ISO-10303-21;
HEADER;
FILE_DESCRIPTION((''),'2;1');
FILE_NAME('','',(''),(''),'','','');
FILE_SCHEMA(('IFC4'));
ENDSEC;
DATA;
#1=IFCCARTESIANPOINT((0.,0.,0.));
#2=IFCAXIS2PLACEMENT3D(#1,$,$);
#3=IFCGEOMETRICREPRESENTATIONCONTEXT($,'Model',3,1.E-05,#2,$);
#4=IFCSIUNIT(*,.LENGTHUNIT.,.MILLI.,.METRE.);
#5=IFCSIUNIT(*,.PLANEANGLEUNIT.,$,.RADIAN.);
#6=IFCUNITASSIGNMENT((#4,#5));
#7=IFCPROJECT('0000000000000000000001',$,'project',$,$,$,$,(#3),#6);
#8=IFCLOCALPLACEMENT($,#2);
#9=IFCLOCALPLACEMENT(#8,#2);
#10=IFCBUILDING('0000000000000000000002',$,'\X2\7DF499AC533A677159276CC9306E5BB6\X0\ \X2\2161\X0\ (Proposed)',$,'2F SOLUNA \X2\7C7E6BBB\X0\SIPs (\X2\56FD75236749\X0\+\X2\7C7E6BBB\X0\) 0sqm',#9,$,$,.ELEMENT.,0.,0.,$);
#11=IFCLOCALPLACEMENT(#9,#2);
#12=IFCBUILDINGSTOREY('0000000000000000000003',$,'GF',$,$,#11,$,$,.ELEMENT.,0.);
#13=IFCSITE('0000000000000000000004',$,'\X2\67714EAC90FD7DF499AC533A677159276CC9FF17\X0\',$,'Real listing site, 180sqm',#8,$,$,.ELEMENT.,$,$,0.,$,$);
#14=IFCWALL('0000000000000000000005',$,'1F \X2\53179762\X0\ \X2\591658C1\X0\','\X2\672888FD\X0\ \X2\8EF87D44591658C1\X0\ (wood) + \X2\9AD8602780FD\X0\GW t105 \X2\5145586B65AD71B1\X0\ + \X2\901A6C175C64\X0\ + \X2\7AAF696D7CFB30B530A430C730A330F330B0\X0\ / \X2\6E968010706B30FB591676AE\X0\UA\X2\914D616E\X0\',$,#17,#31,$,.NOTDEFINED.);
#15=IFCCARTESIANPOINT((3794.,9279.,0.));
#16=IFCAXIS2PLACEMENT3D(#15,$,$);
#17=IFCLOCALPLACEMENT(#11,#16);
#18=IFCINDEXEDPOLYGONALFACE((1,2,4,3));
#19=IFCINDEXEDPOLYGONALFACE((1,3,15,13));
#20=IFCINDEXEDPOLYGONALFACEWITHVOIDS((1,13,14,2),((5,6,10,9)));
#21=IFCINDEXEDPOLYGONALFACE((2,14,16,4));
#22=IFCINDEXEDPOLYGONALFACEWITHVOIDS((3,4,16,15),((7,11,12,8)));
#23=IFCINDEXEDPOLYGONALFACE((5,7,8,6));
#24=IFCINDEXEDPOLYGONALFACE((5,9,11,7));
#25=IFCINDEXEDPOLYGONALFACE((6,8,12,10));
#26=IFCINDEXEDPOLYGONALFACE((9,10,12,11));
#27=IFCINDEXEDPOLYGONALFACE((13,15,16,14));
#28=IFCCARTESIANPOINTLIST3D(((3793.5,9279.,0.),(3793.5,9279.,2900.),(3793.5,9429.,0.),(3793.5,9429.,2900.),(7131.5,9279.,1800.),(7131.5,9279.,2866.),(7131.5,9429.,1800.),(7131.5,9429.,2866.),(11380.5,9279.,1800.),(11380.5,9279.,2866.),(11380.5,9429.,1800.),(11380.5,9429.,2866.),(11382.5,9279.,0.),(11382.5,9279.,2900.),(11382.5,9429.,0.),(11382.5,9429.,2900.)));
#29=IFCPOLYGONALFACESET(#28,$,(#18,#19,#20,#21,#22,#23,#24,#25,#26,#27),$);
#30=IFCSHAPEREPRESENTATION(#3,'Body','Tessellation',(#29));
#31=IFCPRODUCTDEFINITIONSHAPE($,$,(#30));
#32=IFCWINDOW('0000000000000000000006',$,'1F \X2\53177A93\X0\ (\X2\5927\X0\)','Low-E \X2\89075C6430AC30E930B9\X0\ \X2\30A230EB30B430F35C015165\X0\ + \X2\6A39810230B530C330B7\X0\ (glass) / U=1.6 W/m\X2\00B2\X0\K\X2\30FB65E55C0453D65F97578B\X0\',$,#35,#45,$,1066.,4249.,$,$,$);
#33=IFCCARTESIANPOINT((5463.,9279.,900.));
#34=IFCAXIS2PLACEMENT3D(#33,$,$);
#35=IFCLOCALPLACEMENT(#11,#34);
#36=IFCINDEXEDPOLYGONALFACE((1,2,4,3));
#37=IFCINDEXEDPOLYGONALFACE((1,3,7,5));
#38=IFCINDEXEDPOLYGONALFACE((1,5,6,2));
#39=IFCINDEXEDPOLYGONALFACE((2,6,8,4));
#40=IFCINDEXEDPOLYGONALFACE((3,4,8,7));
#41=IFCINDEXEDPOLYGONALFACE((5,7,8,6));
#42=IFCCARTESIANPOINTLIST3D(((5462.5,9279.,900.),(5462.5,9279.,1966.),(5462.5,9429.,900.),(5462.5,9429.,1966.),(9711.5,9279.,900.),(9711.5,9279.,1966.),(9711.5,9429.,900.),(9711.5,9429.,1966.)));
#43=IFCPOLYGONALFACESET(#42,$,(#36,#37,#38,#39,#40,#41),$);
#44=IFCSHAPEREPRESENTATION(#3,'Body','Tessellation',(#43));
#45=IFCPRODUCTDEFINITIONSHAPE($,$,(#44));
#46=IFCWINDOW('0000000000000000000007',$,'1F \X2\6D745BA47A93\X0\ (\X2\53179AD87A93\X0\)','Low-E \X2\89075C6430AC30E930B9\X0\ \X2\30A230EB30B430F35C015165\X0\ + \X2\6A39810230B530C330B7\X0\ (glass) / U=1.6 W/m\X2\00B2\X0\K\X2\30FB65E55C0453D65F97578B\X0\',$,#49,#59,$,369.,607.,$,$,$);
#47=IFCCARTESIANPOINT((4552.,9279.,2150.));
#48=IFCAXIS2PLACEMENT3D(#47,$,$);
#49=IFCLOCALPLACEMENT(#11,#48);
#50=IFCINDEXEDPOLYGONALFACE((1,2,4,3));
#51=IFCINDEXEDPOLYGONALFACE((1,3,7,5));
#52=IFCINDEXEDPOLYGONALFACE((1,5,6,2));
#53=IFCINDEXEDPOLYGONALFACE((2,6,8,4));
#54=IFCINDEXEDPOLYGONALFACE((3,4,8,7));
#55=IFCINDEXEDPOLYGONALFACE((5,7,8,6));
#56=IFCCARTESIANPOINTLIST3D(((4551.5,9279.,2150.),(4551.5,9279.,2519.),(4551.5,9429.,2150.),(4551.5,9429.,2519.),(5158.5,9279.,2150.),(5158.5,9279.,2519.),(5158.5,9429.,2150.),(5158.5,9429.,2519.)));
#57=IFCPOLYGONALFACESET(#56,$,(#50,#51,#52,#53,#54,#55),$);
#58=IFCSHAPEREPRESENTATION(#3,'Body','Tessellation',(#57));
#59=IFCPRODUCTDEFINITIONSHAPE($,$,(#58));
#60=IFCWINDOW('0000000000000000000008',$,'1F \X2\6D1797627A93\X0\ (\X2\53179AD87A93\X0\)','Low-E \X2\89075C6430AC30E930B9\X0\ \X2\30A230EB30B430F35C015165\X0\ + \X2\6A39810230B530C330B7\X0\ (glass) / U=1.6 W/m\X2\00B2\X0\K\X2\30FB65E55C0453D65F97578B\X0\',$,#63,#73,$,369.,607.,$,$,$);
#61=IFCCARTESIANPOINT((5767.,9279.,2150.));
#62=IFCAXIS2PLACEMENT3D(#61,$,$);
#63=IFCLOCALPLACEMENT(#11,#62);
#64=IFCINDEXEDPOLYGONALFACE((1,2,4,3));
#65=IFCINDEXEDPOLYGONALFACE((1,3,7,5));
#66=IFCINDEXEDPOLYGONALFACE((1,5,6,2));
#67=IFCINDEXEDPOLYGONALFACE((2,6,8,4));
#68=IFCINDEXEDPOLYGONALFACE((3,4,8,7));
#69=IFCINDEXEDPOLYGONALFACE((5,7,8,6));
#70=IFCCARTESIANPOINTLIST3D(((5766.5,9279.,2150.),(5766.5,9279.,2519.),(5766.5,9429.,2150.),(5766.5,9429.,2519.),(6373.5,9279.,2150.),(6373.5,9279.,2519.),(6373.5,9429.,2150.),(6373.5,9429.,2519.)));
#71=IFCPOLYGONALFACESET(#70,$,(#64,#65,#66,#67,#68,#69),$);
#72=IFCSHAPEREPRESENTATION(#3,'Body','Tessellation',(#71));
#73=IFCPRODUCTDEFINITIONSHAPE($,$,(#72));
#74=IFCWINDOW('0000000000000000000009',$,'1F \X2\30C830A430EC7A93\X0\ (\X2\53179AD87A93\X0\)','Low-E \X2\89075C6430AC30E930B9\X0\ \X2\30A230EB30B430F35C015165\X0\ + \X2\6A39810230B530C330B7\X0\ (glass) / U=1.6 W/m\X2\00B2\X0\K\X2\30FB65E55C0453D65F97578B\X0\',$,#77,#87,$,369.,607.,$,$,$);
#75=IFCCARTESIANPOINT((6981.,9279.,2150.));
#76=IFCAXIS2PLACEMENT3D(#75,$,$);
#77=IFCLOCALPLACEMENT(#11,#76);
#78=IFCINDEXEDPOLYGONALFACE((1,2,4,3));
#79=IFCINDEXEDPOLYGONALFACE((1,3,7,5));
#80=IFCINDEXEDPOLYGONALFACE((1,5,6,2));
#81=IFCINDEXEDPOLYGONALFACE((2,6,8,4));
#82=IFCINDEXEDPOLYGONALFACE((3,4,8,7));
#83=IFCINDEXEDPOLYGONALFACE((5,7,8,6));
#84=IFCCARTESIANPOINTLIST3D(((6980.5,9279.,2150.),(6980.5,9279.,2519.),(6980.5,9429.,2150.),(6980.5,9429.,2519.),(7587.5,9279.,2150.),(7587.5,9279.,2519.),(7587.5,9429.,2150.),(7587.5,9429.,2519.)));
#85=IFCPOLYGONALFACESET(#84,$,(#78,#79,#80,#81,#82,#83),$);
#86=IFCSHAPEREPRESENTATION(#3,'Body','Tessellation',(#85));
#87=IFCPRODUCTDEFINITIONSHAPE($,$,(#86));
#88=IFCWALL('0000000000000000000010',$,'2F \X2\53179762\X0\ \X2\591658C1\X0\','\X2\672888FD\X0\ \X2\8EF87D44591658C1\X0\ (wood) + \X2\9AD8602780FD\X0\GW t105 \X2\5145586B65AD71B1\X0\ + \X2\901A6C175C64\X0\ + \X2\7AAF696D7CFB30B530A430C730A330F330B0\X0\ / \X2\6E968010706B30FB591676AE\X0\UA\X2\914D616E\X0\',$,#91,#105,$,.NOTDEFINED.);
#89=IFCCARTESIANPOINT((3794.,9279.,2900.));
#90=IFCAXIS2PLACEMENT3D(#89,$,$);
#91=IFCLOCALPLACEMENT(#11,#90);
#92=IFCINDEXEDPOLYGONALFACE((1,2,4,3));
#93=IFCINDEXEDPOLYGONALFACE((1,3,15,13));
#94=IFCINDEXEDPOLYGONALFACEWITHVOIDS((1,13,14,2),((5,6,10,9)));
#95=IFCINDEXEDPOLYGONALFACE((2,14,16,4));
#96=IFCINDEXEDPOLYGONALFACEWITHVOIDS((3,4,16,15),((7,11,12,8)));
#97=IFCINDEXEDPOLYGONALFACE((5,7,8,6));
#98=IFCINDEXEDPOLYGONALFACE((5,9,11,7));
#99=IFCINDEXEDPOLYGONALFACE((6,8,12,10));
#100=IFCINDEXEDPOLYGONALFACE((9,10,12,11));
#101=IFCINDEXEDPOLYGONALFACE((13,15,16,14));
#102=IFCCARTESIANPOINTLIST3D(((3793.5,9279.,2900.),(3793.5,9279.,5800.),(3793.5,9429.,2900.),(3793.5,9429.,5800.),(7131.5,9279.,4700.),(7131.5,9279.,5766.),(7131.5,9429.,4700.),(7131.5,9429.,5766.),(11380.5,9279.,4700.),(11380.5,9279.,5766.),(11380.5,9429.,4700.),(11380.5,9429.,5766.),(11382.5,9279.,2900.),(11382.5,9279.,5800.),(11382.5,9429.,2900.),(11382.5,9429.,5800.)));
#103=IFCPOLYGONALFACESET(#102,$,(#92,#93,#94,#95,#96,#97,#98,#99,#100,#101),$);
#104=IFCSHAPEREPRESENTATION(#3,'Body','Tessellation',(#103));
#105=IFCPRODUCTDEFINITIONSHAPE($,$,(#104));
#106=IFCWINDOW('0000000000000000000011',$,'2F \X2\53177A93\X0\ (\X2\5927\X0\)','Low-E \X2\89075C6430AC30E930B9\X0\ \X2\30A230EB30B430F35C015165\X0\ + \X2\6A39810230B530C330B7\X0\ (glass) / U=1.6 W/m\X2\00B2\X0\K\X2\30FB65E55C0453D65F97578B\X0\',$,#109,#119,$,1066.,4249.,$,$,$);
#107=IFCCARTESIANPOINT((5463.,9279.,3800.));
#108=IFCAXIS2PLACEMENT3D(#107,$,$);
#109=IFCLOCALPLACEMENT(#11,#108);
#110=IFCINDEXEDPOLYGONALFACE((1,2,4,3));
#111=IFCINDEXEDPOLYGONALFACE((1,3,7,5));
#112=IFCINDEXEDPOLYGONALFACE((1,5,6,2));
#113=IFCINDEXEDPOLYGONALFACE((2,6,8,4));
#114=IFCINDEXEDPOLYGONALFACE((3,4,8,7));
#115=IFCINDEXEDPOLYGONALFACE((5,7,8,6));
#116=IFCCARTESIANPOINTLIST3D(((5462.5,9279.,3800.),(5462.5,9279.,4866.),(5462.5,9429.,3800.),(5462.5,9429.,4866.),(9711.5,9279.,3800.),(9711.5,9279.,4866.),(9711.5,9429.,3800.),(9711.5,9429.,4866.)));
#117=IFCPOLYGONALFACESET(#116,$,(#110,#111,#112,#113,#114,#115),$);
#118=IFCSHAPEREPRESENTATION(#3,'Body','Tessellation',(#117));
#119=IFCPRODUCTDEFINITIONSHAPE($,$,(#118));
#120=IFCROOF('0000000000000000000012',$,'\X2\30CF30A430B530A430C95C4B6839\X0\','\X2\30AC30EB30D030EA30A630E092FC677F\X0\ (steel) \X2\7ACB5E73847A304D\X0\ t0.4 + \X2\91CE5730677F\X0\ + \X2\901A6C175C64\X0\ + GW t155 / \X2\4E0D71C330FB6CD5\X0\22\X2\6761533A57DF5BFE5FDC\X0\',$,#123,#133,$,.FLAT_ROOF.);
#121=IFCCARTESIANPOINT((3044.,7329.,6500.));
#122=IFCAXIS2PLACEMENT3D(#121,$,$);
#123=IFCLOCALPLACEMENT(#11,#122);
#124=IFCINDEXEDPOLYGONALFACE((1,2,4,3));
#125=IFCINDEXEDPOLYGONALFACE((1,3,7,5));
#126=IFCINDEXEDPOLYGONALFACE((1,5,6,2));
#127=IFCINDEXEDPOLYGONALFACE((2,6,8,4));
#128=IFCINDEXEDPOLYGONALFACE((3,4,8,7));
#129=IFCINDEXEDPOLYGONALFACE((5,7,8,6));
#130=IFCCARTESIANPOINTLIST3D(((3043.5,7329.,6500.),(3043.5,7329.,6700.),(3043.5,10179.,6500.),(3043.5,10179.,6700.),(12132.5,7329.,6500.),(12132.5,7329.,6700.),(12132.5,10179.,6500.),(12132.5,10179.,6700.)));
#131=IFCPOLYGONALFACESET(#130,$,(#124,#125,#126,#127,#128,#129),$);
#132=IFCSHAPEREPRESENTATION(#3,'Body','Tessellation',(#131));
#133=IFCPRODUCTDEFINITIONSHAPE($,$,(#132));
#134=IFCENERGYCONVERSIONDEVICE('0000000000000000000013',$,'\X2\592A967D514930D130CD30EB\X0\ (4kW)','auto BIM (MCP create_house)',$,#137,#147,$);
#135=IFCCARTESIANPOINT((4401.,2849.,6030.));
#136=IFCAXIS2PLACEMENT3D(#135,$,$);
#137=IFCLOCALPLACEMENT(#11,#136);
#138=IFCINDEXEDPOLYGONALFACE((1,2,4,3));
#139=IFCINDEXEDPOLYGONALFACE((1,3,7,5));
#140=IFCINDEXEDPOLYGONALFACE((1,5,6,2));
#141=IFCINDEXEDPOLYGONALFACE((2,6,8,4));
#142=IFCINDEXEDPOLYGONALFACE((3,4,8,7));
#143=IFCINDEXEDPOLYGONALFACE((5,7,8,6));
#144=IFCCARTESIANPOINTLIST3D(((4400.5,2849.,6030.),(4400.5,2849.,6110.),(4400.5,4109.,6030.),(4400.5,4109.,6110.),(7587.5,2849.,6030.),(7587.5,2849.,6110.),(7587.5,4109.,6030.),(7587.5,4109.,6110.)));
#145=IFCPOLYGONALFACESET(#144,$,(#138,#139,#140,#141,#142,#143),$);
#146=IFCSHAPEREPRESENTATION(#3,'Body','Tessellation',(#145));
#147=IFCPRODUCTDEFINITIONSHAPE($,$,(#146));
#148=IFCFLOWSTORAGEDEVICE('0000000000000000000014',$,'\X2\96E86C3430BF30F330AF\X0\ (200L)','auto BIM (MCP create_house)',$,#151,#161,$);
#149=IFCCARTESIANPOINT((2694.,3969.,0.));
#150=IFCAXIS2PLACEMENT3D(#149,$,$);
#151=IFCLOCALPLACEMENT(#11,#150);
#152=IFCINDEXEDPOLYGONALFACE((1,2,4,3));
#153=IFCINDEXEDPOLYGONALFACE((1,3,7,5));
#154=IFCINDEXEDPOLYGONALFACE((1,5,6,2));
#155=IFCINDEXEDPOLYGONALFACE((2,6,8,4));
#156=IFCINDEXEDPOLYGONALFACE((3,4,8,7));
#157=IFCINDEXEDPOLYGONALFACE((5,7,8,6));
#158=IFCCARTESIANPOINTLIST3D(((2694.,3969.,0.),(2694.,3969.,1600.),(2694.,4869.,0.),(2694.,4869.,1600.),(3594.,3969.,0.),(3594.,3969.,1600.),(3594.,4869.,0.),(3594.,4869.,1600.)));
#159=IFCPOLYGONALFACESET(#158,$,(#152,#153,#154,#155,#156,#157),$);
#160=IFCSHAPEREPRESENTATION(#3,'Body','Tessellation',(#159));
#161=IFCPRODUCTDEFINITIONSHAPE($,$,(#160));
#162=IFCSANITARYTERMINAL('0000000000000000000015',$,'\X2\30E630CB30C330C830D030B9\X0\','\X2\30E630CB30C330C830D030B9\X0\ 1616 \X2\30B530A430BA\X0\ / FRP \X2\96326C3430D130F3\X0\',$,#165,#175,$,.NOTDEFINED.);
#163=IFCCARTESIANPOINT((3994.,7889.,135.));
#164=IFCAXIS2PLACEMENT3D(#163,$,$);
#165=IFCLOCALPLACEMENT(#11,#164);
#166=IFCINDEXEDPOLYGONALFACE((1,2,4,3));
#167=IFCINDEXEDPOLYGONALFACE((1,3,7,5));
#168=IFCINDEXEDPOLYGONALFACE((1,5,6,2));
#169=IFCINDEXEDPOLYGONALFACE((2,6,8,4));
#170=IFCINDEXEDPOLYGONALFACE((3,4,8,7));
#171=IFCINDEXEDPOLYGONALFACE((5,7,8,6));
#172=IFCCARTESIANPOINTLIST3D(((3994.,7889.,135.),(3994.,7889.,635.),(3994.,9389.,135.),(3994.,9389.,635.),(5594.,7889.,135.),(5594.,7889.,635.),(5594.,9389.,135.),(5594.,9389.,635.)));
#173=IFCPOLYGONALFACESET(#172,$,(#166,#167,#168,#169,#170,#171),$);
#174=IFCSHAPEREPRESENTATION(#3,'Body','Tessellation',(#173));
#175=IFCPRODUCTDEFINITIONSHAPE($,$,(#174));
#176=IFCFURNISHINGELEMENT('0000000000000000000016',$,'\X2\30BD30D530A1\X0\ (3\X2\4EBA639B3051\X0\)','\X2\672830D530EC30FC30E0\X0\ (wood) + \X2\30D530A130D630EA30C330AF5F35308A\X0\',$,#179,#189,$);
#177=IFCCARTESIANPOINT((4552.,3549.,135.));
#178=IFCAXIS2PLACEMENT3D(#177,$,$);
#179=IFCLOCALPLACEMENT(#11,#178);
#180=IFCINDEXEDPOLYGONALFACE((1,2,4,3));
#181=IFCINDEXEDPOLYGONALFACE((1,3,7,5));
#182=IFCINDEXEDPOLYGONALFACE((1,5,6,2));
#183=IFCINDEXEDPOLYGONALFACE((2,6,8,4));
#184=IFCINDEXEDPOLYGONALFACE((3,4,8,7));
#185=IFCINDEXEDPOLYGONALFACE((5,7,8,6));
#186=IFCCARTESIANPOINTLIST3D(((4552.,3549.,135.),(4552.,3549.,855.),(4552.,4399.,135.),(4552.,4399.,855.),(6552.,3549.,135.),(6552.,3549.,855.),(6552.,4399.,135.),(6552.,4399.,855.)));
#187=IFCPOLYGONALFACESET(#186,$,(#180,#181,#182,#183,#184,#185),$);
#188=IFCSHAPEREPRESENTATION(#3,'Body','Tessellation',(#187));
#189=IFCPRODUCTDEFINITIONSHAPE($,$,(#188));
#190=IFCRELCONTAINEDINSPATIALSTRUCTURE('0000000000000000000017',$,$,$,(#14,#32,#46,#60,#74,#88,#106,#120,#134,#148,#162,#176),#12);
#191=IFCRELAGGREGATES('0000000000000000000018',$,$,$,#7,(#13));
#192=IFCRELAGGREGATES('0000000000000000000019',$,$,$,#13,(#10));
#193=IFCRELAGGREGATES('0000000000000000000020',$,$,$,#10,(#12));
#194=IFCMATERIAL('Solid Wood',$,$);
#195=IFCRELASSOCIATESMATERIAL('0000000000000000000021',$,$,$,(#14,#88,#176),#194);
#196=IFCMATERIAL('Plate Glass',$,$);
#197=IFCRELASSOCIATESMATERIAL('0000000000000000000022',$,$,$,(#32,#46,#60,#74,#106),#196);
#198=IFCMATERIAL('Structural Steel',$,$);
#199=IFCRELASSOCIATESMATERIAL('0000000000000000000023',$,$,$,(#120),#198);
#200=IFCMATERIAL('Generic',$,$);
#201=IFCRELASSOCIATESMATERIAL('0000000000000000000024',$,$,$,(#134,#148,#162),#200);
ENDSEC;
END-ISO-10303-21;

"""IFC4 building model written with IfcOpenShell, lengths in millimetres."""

from ifc_helpers import new_model, si_unit, frame, frame_2d, origin, place, context, project, spatial, rectangle, extrude, material, element, fill, save


model = new_model("IFC4")

# Units and contexts
model_context = context("Model", 3, precision=1e-05, world=origin())
ifc_project = project(units=[si_unit("LENGTHUNIT", "METRE", prefix="MILLI"), si_unit("PLANEANGLEUNIT", "RADIAN")], contexts=[model_context])

# Site, building, storey
site_placement = place(None, origin())
site = spatial("IfcSite", under=ifc_project, at=site_placement, Name="東京都練馬区東大泉７", ObjectType="Real listing site, 180sqm", CompositionType="ELEMENT", RefElevation=0.0)
building_placement = place(site_placement, origin())
building = spatial("IfcBuilding", under=site, at=building_placement, Name="練馬区東大泉の家 Ⅱ (Proposed)", ObjectType="2F SOLUNA 籾殻SIPs (国産杉+籾殻) 0sqm", CompositionType="ELEMENT", ElevationOfRefHeight=0.0, ElevationOfTerrain=0.0)
storey_placement = place(building_placement, origin())
storey = spatial("IfcBuildingStorey", under=building, at=storey_placement, Name="GF", CompositionType="ELEMENT", Elevation=0.0)

# Wall, openings, windows
ifc_material_1 = material(Name="Solid Wood")
wall_1_placement = place(storey_placement, frame((3794.0, 9279.0, 0.0)))
wall_1 = element("IfcWall", 1, at=wall_1_placement, inside=storey, material=ifc_material_1, Name="1F 北面 外壁", Description="木製 軸組外壁 (wood) + 高性能GW t105 充填断熱 + 通気層 + 窯業系サイディング / 準耐火・外皮UA配慮", PredefinedType="NOTDEFINED", context=model_context, shape_type="SweptSolid", body=[
    extrude(rectangle(XDim=7589.0, YDim=150.0, at=frame_2d((3794.0, 75.0))), frame((3794.0, 9279.0, 0.0)), (0.0, 0.0, 1.0), 2900.0),
])
opening_1_placement = place(storey_placement, frame((5463.0, 9279.0, 900.0)))
opening_1 = element("IfcOpeningElement", 2, at=opening_1_placement, cuts=wall_1, PredefinedType="NOTDEFINED", context=model_context, shape_type="SweptSolid", body=[
    extrude(rectangle(XDim=4249.0, YDim=150.0, at=frame_2d((2124.0, 75.0))), frame((5463.0, 9279.0, 900.0)), (0.0, 0.0, 1.0), 1066.0),
])
opening_2_placement = place(storey_placement, frame((4552.0, 9279.0, 2150.0)))
opening_2 = element("IfcOpeningElement", 3, at=opening_2_placement, cuts=wall_1, PredefinedType="NOTDEFINED", context=model_context, shape_type="SweptSolid", body=[
    extrude(rectangle(XDim=607.0, YDim=150.0, at=frame_2d((303.0, 75.0))), frame((4552.0, 9279.0, 2150.0)), (0.0, 0.0, 1.0), 369.0),
])
opening_3_placement = place(storey_placement, frame((5767.0, 9279.0, 2150.0)))
opening_3 = element("IfcOpeningElement", 4, at=opening_3_placement, cuts=wall_1, PredefinedType="NOTDEFINED", context=model_context, shape_type="SweptSolid", body=[
    extrude(rectangle(XDim=607.0, YDim=150.0, at=frame_2d((303.0, 75.0))), frame((5767.0, 9279.0, 2150.0)), (0.0, 0.0, 1.0), 369.0),
])
opening_4_placement = place(storey_placement, frame((6981.0, 9279.0, 2150.0)))
opening_4 = element("IfcOpeningElement", 5, at=opening_4_placement, cuts=wall_1, PredefinedType="NOTDEFINED", context=model_context, shape_type="SweptSolid", body=[
    extrude(rectangle(XDim=607.0, YDim=150.0, at=frame_2d((303.0, 75.0))), frame((6981.0, 9279.0, 2150.0)), (0.0, 0.0, 1.0), 369.0),
])
ifc_material_2 = material(Name="Plate Glass")
window_1_placement = place(storey_placement, frame((5463.0, 9279.0, 900.0)))
window_1 = element("IfcWindow", 6, at=window_1_placement, inside=storey, material=ifc_material_2, Name="1F 北窓 (大)", Description="Low-E 複層ガラス アルゴン封入 + 樹脂サッシ (glass) / U=1.6 W/m²K・日射取得型", OverallHeight=1066.0, OverallWidth=4249.0, context=model_context, shape_type="SweptSolid", body=[
    extrude(rectangle(XDim=4249.0, YDim=150.0, at=frame_2d((2124.0, 75.0))), frame((5463.0, 9279.0, 900.0)), (0.0, 0.0, 1.0), 1066.0),
])
fill(opening_1, window_1)
window_2_placement = place(storey_placement, frame((4552.0, 9279.0, 2150.0)))
window_2 = element("IfcWindow", 7, at=window_2_placement, inside=storey, material=ifc_material_2, Name="1F 浴室窓 (北高窓)", Description="Low-E 複層ガラス アルゴン封入 + 樹脂サッシ (glass) / U=1.6 W/m²K・日射取得型", OverallHeight=369.0, OverallWidth=607.0, context=model_context, shape_type="SweptSolid", body=[
    extrude(rectangle(XDim=607.0, YDim=150.0, at=frame_2d((303.0, 75.0))), frame((4552.0, 9279.0, 2150.0)), (0.0, 0.0, 1.0), 369.0),
])
fill(opening_2, window_2)
window_3_placement = place(storey_placement, frame((5767.0, 9279.0, 2150.0)))
window_3 = element("IfcWindow", 8, at=window_3_placement, inside=storey, material=ifc_material_2, Name="1F 洗面窓 (北高窓)", Description="Low-E 複層ガラス アルゴン封入 + 樹脂サッシ (glass) / U=1.6 W/m²K・日射取得型", OverallHeight=369.0, OverallWidth=607.0, context=model_context, shape_type="SweptSolid", body=[
    extrude(rectangle(XDim=607.0, YDim=150.0, at=frame_2d((303.0, 75.0))), frame((5767.0, 9279.0, 2150.0)), (0.0, 0.0, 1.0), 369.0),
])
fill(opening_3, window_3)
window_4_placement = place(storey_placement, frame((6981.0, 9279.0, 2150.0)))
window_4 = element("IfcWindow", 9, at=window_4_placement, inside=storey, material=ifc_material_2, Name="1F トイレ窓 (北高窓)", Description="Low-E 複層ガラス アルゴン封入 + 樹脂サッシ (glass) / U=1.6 W/m²K・日射取得型", OverallHeight=369.0, OverallWidth=607.0, context=model_context, shape_type="SweptSolid", body=[
    extrude(rectangle(XDim=607.0, YDim=150.0, at=frame_2d((303.0, 75.0))), frame((6981.0, 9279.0, 2150.0)), (0.0, 0.0, 1.0), 369.0),
])
fill(opening_4, window_4)

# Wall, opening, window
wall_2_placement = place(storey_placement, frame((3794.0, 9279.0, 2900.0)))
wall_2 = element("IfcWall", 10, at=wall_2_placement, inside=storey, material=ifc_material_1, Name="2F 北面 外壁", Description="木製 軸組外壁 (wood) + 高性能GW t105 充填断熱 + 通気層 + 窯業系サイディング / 準耐火・外皮UA配慮", PredefinedType="NOTDEFINED", context=model_context, shape_type="SweptSolid", body=[
    extrude(rectangle(XDim=7589.0, YDim=150.0, at=frame_2d((3794.0, 75.0))), frame((3794.0, 9279.0, 2900.0)), (0.0, 0.0, 1.0), 2900.0),
])
opening_5_placement = place(storey_placement, frame((5463.0, 9279.0, 3800.0)))
opening_5 = element("IfcOpeningElement", 11, at=opening_5_placement, cuts=wall_2, PredefinedType="NOTDEFINED", context=model_context, shape_type="SweptSolid", body=[
    extrude(rectangle(XDim=4249.0, YDim=150.0, at=frame_2d((2124.0, 75.0))), frame((5463.0, 9279.0, 3800.0)), (0.0, 0.0, 1.0), 1066.0),
])
window_5_placement = place(storey_placement, frame((5463.0, 9279.0, 3800.0)))
window_5 = element("IfcWindow", 12, at=window_5_placement, inside=storey, material=ifc_material_2, Name="2F 北窓 (大)", Description="Low-E 複層ガラス アルゴン封入 + 樹脂サッシ (glass) / U=1.6 W/m²K・日射取得型", OverallHeight=1066.0, OverallWidth=4249.0, context=model_context, shape_type="SweptSolid", body=[
    extrude(rectangle(XDim=4249.0, YDim=150.0, at=frame_2d((2124.0, 75.0))), frame((5463.0, 9279.0, 3800.0)), (0.0, 0.0, 1.0), 1066.0),
])
fill(opening_5, window_5)

# Roof
ifc_material_3 = material(Name="Structural Steel")
roof_placement = place(storey_placement, frame((3044.0, 7329.0, 6500.0)))
element("IfcRoof", 13, at=roof_placement, inside=storey, material=ifc_material_3, Name="ハイサイド屋根", Description="ガルバリウム鋼板 (steel) 立平葺き t0.4 + 野地板 + 通気層 + GW t155 / 不燃・法22条区域対応", PredefinedType="FLAT_ROOF", context=model_context, shape_type="SweptSolid", body=[
    extrude(rectangle(XDim=9089.0, YDim=2850.0, at=frame_2d((4544.0, 1425.0))), frame((3044.0, 7329.0, 6500.0)), (0.0, 0.0, 1.0), 200.0),
])

# Energy conversion device
ifc_material_4 = material(Name="Generic")
energy_conversion_device_placement = place(storey_placement, frame((4401.0, 2849.0, 6030.0)))
element("IfcEnergyConversionDevice", 14, at=energy_conversion_device_placement, inside=storey, material=ifc_material_4, Name="太陽光パネル (4kW)", Description="auto BIM (MCP create_house)", context=model_context, shape_type="SweptSolid", body=[
    extrude(rectangle(XDim=3187.0, YDim=1260.0, at=frame_2d((1593.0, 630.0))), frame((4401.0, 2849.0, 6030.0)), (0.0, 0.0, 1.0), 80.0),
])

# Flow storage device
flow_storage_device_placement = place(storey_placement, frame((2694.0, 3969.0, 0.0)))
element("IfcFlowStorageDevice", 15, at=flow_storage_device_placement, inside=storey, material=ifc_material_4, Name="雨水タンク (200L)", Description="auto BIM (MCP create_house)", context=model_context, shape_type="SweptSolid", body=[
    extrude(rectangle(XDim=900.0, YDim=900.0, at=frame_2d((450.0, 450.0))), frame((2694.0, 3969.0, 0.0)), (0.0, 0.0, 1.0), 1600.0),
])

# Sanitary terminal
sanitary_terminal_placement = place(storey_placement, frame((3994.0, 7889.0, 135.0)))
element("IfcSanitaryTerminal", 16, at=sanitary_terminal_placement, inside=storey, material=ifc_material_4, Name="ユニットバス", Description="ユニットバス 1616 サイズ / FRP 防水パン", PredefinedType="NOTDEFINED", context=model_context, shape_type="SweptSolid", body=[
    extrude(rectangle(XDim=1600.0, YDim=1500.0, at=frame_2d((800.0, 750.0))), frame((3994.0, 7889.0, 135.0)), (0.0, 0.0, 1.0), 500.0),
])

# Furnishing element
furnishing_1_placement = place(storey_placement, frame((4552.0, 3549.0, 135.0)))
element("IfcFurnishingElement", 17, at=furnishing_1_placement, inside=storey, material=ifc_material_1, Name="ソファ (3人掛け)", Description="木フレーム (wood) + ファブリック張り", context=model_context, shape_type="SweptSolid", body=[
    extrude(rectangle(XDim=2000.0, YDim=850.0, at=frame_2d((1000.0, 425.0))), frame((4552.0, 3549.0, 135.0)), (0.0, 0.0, 1.0), 720.0),
])

save(model, "model.ifc")
